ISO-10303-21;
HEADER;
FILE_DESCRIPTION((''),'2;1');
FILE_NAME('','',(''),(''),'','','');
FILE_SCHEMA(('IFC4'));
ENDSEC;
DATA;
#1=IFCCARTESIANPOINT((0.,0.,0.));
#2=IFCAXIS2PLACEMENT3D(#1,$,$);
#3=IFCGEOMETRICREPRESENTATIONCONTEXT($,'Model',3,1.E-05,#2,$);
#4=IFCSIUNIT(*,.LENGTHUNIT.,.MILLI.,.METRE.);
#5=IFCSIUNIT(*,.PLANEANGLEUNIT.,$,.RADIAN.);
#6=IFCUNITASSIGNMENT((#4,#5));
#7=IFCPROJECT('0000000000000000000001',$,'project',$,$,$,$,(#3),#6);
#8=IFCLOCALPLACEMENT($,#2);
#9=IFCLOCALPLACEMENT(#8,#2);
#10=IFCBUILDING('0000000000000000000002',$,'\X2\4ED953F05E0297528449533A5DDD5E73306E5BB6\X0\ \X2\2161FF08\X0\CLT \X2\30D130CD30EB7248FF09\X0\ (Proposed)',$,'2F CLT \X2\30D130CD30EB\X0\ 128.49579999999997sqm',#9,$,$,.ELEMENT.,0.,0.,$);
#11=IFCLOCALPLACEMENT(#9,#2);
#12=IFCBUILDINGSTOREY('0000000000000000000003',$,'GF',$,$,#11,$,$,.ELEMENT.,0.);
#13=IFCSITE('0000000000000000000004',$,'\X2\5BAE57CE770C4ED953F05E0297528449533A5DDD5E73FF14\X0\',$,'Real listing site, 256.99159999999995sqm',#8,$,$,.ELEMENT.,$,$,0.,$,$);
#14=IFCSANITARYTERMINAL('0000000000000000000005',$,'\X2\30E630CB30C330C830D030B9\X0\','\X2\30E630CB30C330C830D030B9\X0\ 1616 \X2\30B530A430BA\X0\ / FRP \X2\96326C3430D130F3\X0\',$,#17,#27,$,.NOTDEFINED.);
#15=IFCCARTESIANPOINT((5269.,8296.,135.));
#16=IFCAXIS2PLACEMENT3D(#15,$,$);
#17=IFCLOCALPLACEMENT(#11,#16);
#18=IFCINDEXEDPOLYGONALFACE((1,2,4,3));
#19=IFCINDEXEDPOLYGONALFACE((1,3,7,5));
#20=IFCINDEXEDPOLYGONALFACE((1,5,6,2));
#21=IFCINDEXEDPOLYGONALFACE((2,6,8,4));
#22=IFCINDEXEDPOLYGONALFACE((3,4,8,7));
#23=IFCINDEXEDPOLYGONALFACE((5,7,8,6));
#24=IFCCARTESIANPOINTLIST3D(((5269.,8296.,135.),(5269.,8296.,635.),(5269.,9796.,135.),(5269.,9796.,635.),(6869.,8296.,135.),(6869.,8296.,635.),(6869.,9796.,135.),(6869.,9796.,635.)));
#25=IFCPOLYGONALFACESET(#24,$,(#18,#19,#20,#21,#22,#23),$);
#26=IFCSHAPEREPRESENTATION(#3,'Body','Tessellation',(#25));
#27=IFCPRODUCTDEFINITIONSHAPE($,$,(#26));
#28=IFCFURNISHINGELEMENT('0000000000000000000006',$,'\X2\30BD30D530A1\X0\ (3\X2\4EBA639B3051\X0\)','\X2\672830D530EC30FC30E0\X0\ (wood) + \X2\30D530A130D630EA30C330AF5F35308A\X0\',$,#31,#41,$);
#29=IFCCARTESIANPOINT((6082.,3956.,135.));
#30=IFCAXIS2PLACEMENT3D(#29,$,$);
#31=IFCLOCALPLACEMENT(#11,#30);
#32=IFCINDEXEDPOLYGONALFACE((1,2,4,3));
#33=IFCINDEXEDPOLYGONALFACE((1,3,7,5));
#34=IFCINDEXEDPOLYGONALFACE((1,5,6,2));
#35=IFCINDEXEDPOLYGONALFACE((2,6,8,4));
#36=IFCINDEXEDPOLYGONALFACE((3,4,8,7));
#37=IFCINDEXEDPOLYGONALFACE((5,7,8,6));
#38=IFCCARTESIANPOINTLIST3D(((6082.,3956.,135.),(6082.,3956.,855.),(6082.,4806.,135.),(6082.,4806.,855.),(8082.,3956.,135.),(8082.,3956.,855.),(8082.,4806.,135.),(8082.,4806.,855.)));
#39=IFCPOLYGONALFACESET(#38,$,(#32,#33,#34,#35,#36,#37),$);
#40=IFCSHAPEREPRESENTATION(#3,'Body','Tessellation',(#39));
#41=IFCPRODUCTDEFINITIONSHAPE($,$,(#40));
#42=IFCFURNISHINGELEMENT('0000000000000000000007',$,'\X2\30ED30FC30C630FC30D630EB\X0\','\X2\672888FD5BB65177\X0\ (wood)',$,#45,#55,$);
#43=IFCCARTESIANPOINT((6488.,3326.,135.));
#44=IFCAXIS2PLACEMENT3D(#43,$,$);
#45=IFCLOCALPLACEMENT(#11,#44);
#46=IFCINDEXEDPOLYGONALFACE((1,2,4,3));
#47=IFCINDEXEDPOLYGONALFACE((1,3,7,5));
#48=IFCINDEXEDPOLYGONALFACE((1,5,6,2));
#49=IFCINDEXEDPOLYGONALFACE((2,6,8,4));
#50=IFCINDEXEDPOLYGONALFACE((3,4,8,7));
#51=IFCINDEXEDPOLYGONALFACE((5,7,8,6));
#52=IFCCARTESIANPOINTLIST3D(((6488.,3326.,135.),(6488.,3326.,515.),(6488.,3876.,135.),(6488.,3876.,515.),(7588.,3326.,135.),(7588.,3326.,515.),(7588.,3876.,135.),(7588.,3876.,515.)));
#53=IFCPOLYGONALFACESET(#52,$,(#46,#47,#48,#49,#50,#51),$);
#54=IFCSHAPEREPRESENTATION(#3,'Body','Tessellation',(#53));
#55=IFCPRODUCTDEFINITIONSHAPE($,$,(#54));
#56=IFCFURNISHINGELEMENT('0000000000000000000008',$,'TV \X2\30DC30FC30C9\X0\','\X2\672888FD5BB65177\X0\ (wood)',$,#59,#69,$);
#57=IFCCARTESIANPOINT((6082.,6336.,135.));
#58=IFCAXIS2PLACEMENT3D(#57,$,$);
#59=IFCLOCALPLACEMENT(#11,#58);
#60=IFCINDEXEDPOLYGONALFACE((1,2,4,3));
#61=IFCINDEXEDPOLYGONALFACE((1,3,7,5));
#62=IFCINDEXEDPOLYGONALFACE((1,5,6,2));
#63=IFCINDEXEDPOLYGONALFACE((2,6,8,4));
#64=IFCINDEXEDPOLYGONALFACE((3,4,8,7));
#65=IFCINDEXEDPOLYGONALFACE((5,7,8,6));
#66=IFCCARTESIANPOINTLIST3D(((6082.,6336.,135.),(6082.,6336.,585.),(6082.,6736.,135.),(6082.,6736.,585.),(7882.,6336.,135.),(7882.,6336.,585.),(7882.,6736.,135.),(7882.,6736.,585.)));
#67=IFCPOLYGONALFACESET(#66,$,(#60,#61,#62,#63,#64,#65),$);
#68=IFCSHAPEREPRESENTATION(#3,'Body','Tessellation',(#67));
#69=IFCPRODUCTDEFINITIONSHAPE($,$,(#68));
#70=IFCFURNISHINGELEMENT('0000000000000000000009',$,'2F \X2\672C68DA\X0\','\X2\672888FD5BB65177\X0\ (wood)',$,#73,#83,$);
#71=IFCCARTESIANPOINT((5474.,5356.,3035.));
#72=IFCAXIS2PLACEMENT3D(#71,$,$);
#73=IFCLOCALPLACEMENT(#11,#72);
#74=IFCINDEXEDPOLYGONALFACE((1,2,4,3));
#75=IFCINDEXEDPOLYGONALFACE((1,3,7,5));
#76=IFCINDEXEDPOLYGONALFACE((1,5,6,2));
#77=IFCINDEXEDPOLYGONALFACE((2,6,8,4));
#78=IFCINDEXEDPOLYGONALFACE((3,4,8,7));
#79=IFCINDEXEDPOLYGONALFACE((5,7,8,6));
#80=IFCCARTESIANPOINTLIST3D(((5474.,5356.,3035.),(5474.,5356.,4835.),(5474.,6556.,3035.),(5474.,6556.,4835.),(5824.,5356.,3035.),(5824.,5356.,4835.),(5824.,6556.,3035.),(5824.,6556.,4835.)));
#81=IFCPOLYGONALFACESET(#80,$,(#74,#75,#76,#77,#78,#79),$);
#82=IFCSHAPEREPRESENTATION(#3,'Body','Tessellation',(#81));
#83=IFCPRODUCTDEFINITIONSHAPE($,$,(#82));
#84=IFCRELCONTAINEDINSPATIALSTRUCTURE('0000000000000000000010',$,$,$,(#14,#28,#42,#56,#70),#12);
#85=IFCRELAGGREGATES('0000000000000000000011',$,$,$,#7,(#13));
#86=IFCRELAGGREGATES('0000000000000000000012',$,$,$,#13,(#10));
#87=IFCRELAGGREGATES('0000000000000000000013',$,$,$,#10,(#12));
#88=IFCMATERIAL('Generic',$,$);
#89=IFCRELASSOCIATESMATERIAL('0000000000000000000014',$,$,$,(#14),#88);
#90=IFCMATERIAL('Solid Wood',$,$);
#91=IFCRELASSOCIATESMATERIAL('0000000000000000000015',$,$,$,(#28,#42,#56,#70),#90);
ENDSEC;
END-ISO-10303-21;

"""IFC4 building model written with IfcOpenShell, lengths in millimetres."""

from ifc_helpers import new_model, si_unit, frame, frame_2d, origin, place, context, project, spatial, rectangle, extrude, material, element, save


model = new_model("IFC4")

# Units and contexts
model_context = context("Model", 3, precision=1e-05, world=origin())
ifc_project = project(units=[si_unit("LENGTHUNIT", "METRE", prefix="MILLI"), si_unit("PLANEANGLEUNIT", "RADIAN")], contexts=[model_context])

# Site, building, storey
site_placement = place(None, origin())
site = spatial("IfcSite", under=ifc_project, at=site_placement, Name="宮城県仙台市青葉区川平４", ObjectType="Real listing site, 256.99159999999995sqm", CompositionType="ELEMENT", RefElevation=0.0)
building_placement = place(site_placement, origin())
building = spatial("IfcBuilding", under=site, at=building_placement, Name="仙台市青葉区川平の家 Ⅱ（CLT パネル版） (Proposed)", ObjectType="2F CLT パネル 128.49579999999997sqm", CompositionType="ELEMENT", ElevationOfRefHeight=0.0, ElevationOfTerrain=0.0)
storey_placement = place(building_placement, origin())
storey = spatial("IfcBuildingStorey", under=building, at=storey_placement, Name="GF", CompositionType="ELEMENT", Elevation=0.0)

# Shared definitions
ifc_material_1 = material(Name="Solid Wood")

# Sanitary terminal
ifc_material_2 = material(Name="Generic")
sanitary_terminal_placement = place(storey_placement, frame((5269.0, 8296.0, 135.0)))
element("IfcSanitaryTerminal", 1, at=sanitary_terminal_placement, inside=storey, material=ifc_material_2, Name="ユニットバス", Description="ユニットバス 1616 サイズ / FRP 防水パン", PredefinedType="NOTDEFINED", context=model_context, shape_type="SweptSolid", body=[
    extrude(rectangle(XDim=1600.0, YDim=1500.0, at=frame_2d((800.0, 750.0))), frame((5269.0, 8296.0, 135.0)), (0.0, 0.0, 1.0), 500.0),
])

# Furnishing elements
furnishing_1_placement = place(storey_placement, frame((6082.0, 3956.0, 135.0)))
element("IfcFurnishingElement", 2, at=furnishing_1_placement, inside=storey, material=ifc_material_1, Name="ソファ (3人掛け)", Description="木フレーム (wood) + ファブリック張り", context=model_context, shape_type="SweptSolid", body=[
    extrude(rectangle(XDim=2000.0, YDim=850.0, at=frame_2d((1000.0, 425.0))), frame((6082.0, 3956.0, 135.0)), (0.0, 0.0, 1.0), 720.0),
])
furnishing_2_placement = place(storey_placement, frame((6488.0, 3326.0, 135.0)))
element("IfcFurnishingElement", 3, at=furnishing_2_placement, inside=storey, material=ifc_material_1, Name="ローテーブル", Description="木製家具 (wood)", context=model_context, shape_type="SweptSolid", body=[
    extrude(rectangle(XDim=1100.0, YDim=550.0, at=frame_2d((550.0, 275.0))), frame((6488.0, 3326.0, 135.0)), (0.0, 0.0, 1.0), 380.0),
])
furnishing_3_placement = place(storey_placement, frame((6082.0, 6336.0, 135.0)))
element("IfcFurnishingElement", 4, at=furnishing_3_placement, inside=storey, material=ifc_material_1, Name="TV ボード", Description="木製家具 (wood)", context=model_context, shape_type="SweptSolid", body=[
    extrude(rectangle(XDim=1800.0, YDim=400.0, at=frame_2d((900.0, 200.0))), frame((6082.0, 6336.0, 135.0)), (0.0, 0.0, 1.0), 450.0),
])
furnishing_4_placement = place(storey_placement, frame((5474.0, 5356.0, 3035.0)))
element("IfcFurnishingElement", 5, at=furnishing_4_placement, inside=storey, material=ifc_material_1, Name="2F 本棚", Description="木製家具 (wood)", context=model_context, shape_type="SweptSolid", body=[
    extrude(rectangle(XDim=350.0, YDim=1200.0, at=frame_2d((175.0, 600.0))), frame((5474.0, 5356.0, 3035.0)), (0.0, 0.0, 1.0), 1800.0),
])

save(model, "model.ifc")
